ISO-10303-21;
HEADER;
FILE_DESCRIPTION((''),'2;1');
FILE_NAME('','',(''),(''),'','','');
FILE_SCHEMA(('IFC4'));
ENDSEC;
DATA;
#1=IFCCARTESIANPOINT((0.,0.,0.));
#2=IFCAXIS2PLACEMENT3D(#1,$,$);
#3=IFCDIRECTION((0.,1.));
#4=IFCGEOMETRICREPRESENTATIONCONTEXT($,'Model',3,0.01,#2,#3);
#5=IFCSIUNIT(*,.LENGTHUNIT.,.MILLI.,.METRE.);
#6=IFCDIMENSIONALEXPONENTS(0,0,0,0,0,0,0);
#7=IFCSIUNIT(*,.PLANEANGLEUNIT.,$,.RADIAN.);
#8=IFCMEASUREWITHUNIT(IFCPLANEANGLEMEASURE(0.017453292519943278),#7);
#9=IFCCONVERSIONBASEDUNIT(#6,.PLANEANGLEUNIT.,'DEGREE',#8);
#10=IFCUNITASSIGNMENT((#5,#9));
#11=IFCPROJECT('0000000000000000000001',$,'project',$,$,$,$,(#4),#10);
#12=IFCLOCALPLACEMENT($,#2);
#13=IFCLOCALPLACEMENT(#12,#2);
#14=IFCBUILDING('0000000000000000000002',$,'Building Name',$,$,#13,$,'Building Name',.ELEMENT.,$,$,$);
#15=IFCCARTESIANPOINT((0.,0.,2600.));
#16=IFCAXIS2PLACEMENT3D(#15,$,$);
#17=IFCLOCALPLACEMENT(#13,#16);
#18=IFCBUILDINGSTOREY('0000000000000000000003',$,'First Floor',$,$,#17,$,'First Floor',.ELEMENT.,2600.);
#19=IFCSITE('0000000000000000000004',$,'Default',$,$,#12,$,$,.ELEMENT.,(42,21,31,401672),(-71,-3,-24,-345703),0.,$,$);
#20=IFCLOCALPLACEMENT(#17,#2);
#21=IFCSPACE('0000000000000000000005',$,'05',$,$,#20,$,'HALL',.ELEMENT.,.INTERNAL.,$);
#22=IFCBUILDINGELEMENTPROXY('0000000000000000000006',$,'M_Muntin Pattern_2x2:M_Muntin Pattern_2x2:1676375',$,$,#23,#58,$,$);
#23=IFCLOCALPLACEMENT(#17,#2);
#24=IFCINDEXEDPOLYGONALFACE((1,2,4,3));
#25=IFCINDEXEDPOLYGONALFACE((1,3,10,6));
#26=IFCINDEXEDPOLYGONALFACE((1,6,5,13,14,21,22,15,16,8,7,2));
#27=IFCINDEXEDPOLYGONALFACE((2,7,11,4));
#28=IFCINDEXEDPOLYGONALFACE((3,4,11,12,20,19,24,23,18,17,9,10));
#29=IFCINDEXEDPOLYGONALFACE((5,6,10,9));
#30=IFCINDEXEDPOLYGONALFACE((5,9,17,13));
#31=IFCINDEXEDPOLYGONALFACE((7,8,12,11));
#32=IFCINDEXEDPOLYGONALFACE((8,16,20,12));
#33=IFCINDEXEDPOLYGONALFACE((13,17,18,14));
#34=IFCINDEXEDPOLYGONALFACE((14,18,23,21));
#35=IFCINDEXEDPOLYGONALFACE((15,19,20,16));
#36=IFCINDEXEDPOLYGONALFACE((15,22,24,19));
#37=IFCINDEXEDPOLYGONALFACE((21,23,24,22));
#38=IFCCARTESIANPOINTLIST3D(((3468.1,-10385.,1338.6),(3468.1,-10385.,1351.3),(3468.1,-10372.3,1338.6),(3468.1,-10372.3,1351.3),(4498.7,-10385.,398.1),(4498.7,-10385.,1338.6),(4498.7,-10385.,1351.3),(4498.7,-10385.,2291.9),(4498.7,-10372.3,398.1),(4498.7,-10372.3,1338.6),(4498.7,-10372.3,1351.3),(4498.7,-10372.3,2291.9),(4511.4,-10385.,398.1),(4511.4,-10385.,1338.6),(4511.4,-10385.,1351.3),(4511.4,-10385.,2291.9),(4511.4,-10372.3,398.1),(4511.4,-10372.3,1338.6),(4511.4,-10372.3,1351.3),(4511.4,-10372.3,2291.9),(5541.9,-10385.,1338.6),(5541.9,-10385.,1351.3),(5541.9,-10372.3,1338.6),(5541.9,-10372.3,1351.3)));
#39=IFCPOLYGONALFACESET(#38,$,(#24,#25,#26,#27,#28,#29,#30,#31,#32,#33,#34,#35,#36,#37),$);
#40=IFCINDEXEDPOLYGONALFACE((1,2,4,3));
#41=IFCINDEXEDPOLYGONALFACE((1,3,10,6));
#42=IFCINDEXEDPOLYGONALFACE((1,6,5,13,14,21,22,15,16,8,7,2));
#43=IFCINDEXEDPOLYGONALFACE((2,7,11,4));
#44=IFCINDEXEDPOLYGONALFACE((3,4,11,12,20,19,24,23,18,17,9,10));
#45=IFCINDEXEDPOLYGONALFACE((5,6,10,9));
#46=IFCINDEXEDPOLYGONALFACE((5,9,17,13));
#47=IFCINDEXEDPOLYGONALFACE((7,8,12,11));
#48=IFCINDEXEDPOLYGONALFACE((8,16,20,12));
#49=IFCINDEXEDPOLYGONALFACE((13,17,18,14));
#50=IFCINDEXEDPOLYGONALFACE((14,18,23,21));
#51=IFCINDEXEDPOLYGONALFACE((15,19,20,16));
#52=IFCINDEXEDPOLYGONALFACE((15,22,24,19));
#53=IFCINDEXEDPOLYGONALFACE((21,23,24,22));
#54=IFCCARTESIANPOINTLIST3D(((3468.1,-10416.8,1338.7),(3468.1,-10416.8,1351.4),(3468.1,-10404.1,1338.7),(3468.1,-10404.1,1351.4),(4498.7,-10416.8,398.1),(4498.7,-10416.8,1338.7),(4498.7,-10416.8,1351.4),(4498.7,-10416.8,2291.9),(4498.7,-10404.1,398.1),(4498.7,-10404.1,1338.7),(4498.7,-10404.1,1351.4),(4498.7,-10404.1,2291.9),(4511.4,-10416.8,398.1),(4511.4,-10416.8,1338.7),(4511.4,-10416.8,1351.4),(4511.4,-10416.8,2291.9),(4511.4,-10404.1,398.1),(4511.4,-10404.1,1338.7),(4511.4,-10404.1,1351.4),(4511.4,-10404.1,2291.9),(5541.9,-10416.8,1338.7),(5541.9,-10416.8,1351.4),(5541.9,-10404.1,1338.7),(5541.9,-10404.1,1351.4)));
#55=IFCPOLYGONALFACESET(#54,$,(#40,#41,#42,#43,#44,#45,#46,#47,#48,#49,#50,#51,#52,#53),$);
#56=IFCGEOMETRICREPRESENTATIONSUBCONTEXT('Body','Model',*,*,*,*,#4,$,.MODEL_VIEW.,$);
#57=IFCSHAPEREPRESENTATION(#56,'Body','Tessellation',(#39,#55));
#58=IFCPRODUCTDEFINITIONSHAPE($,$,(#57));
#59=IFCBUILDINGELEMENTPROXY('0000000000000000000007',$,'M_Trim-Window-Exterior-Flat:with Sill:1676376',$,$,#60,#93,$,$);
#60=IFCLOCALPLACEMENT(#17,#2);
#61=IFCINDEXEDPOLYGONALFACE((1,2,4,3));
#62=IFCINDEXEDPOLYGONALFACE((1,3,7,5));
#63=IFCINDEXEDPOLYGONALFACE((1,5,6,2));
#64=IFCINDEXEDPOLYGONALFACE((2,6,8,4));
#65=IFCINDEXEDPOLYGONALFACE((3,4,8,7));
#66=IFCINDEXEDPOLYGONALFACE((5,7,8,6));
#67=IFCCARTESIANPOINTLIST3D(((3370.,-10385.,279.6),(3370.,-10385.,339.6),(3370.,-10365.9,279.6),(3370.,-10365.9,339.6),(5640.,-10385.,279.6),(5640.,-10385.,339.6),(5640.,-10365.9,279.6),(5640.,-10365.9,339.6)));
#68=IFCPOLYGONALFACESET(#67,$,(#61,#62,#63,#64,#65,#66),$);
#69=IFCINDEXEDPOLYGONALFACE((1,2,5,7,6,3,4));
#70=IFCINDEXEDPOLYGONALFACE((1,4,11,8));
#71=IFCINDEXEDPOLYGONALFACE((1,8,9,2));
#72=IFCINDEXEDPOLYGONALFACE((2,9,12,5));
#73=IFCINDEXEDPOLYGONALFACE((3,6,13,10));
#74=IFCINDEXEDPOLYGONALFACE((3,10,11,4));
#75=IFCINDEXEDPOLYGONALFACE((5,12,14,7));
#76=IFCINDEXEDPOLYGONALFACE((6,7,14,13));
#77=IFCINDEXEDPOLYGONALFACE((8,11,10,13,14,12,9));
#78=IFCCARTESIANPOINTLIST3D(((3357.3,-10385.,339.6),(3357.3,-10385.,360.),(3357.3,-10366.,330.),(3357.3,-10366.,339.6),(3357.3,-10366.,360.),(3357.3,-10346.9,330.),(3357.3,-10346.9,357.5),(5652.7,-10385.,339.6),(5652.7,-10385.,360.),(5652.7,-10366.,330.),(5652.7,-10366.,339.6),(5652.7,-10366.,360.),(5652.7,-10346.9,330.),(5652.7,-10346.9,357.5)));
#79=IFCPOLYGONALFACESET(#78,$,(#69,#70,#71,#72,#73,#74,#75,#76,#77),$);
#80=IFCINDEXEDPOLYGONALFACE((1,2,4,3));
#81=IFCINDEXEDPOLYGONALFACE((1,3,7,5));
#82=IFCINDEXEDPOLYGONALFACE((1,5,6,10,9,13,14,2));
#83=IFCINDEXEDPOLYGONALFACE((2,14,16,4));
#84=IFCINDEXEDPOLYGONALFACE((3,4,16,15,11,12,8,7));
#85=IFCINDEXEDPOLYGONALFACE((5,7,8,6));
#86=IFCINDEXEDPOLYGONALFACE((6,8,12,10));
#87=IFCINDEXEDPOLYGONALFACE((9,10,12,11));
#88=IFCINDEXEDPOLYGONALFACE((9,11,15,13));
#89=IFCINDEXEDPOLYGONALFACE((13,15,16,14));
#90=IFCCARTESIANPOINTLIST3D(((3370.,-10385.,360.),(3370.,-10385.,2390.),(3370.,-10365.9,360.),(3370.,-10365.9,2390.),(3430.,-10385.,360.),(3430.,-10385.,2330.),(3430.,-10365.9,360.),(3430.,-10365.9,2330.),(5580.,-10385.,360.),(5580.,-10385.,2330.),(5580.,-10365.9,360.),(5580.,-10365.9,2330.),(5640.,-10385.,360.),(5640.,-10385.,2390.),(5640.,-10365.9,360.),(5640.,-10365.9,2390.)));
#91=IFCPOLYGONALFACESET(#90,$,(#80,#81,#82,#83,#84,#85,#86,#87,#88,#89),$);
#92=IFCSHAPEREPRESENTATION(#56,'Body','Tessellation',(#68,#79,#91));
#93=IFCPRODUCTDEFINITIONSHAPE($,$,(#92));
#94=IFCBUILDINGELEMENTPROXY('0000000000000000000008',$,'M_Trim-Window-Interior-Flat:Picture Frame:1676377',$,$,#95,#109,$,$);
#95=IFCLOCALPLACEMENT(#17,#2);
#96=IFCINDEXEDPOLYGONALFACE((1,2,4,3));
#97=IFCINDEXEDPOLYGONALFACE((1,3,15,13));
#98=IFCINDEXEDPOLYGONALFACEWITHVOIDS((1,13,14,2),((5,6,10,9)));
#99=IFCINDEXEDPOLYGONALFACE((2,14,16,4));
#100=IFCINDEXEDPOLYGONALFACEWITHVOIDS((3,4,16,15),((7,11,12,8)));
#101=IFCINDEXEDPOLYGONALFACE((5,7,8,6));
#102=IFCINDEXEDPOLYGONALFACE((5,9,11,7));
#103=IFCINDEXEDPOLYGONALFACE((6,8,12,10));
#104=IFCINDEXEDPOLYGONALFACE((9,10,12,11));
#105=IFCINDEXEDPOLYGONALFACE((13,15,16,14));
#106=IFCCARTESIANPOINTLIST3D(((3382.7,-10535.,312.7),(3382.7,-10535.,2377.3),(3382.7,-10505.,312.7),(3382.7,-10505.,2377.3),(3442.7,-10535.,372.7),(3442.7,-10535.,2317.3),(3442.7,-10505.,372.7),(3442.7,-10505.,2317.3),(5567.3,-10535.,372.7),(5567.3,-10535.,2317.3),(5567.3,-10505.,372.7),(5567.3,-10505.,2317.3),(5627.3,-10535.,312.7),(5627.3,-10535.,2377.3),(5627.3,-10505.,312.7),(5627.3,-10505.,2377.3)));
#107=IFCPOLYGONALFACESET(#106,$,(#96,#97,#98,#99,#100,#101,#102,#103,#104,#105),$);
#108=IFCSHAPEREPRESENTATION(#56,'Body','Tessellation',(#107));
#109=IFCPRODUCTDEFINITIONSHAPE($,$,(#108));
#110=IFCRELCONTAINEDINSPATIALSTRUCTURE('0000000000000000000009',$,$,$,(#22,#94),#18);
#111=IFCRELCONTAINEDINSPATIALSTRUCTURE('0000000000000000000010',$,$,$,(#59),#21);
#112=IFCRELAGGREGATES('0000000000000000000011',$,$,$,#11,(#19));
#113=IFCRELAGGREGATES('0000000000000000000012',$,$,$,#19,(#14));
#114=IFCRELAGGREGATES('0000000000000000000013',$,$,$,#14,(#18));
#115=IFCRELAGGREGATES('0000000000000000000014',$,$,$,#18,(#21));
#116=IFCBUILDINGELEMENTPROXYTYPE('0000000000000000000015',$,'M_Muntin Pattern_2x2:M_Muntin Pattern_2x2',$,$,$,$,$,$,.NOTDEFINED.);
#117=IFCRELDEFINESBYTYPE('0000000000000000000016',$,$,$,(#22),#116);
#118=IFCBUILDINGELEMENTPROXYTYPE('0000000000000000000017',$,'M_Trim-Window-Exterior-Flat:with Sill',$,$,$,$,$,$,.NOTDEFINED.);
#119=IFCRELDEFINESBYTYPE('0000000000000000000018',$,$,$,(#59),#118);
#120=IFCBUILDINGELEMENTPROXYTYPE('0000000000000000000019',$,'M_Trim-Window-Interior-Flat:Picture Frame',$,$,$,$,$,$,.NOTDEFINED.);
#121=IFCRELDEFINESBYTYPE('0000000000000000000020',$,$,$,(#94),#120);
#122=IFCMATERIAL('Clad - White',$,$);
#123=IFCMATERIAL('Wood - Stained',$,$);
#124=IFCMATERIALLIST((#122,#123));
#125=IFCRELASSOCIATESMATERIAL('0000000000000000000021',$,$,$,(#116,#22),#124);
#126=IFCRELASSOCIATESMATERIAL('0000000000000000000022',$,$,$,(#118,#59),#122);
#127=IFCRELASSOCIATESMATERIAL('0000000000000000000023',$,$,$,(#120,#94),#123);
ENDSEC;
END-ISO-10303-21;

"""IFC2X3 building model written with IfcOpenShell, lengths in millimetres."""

from ifc_helpers import new_model, entity, si_unit, converted_unit, direction, frame, frame_2d, origin, place, context, subcontext, project, spatial, polyline, rectangle, outline, extrude, source, transform, mapped, material, material_list, type_object, type_shapes, element, save


model = new_model("IFC2X3")

# Units and contexts
model_context = context("Model", 3, precision=0.01, world=origin(), true_north=direction((0.0, 1.0)))
body_context = subcontext(model_context, "Body", "Model", "MODEL_VIEW")
ifc_project = project(units=[si_unit("LENGTHUNIT", "METRE", prefix="MILLI"), converted_unit("PLANEANGLEUNIT", "DEGREE", entity("IfcPlaneAngleMeasure", 0.017453292519943278), si_unit("PLANEANGLEUNIT", "RADIAN"), dimensions=[0, 0, 0, 0, 0, 0, 0])], contexts=[model_context])

# Site, building, storey
site_placement = place(None, origin())
site = spatial("IfcSite", under=ifc_project, at=site_placement, Name="Default", CompositionType="ELEMENT", RefLatitude=(42, 21, 31, 401672), RefLongitude=(-71, -3, -24, -345703), RefElevation=0.0)
building_placement = place(site_placement, origin())
building = spatial("IfcBuilding", under=site, at=building_placement, Name="Building Name", LongName="Building Name", CompositionType="ELEMENT")
storey_placement = place(building_placement, frame((0.0, 0.0, 2600.0)))
storey = spatial("IfcBuildingStorey", under=building, at=storey_placement, Name="First Floor", LongName="First Floor", CompositionType="ELEMENT", Elevation=2600.0)

# Shared definitions
ifc_material_1 = material(Name="Clad - White")
ifc_material_2 = material(Name="Wood - Stained")
ifc_material_list_1 = material_list([ifc_material_1, ifc_material_2])

# Building element proxy
building_element_proxy_type_1 = type_object("IfcBuildingElementProxyType", Name="M_Muntin Pattern_2x2:M_Muntin Pattern_2x2", PredefinedType="NOTDEFINED", material=ifc_material_list_1)
shared_shape_1 = source(origin(), body_context, "Body", "SweptSolid", [
    extrude(outline(polyline([(6.4, -6.4), (946.9, -6.4), (946.9, 6.3), (6.4, 6.3), (6.4, 1036.9), (-6.3, 1036.9), (-6.3, 6.3), (-946.9, 6.3), (-946.9, -6.4), (-6.3, -6.4), (-6.3, -1036.9), (6.4, -1036.9), (6.4, -6.4)])), frame((0.0, -22.2, 946.9), z_axis=(0.0, 1.0, 0.0), x_axis=(0.0, 0.0, 1.0)), (0.0, 0.0, 1.0), 12.7),
    extrude(outline(polyline([(6.4, -6.4), (946.9, -6.4), (946.9, 6.3), (6.4, 6.3), (6.4, 1036.9), (-6.3, 1036.9), (-6.3, 6.3), (-946.9, 6.3), (-946.9, -6.4), (-6.3, -6.4), (-6.3, -1036.9), (6.4, -1036.9), (6.4, -6.4)])), frame((0.0, 9.5, 946.9), z_axis=(0.0, 1.0, 0.0), x_axis=(0.0, 0.0, 1.0)), (0.0, 0.0, 1.0), 12.7),
])
type_shapes(building_element_proxy_type_1, [shared_shape_1])
proxy_1_placement = place(storey_placement, frame((4505.0, -10394.5, 398.1), z_axis=(0.0, 0.0, 1.0), x_axis=(-1.0, 0.0, 0.0)))
element("IfcBuildingElementProxy", 1, at=proxy_1_placement, inside=storey, type_object=building_element_proxy_type_1, material=ifc_material_list_1, Name="M_Muntin Pattern_2x2:M_Muntin Pattern_2x2:1676375", context=body_context, shape_type="MappedRepresentation", body=[
    mapped(shared_shape_1, transform((0.0, 0.0, 0.0), scale=1.0)),
])

# Shared definitions
space_1_placement = place(storey_placement, origin())
space_1 = spatial("IfcSpace", under=storey, at=space_1_placement, Name="05", LongName="HALL", CompositionType="ELEMENT", InteriorOrExteriorSpace="INTERNAL")

# Building element proxies
building_element_proxy_type_2 = type_object("IfcBuildingElementProxyType", Name="M_Trim-Window-Exterior-Flat:with Sill", PredefinedType="NOTDEFINED", material=ifc_material_1)
shared_shape_2 = source(origin(), body_context, "Body", "SweptSolid", [
    extrude(rectangle(XDim=2270.0, YDim=60.0, at=frame_2d((0.0, 0.0), x_axis=(1.0, 0.0))), frame((0.0, -2020.4, 0.0), z_axis=(0.0, 0.0, 1.0), x_axis=(-1.0, 0.0, 0.0)), (0.0, 0.0, 1.0), 19.0),
    extrude(outline(polyline([(-19.0, -15.2), (0.0, -15.2), (0.0, -5.7), (19.0, -5.7), (19.0, 14.8), (0.0, 14.8), (-19.0, 12.3), (-19.0, -15.2)])), frame((-1147.7, -1984.8, 19.0), z_axis=(1.0, 0.0, 0.0), x_axis=(0.0, 0.0, -1.0)), (0.0, 0.0, 1.0), 2295.4),
    extrude(outline(polyline([(-1030.0, -1135.0), (1000.0, -1135.0), (1000.0, -1075.0), (-970.0, -1075.0), (-970.0, 1075.0), (1000.0, 1075.0), (1000.0, 1135.0), (-1030.0, 1135.0), (-1030.0, -1135.0)])), frame((0.0, -970.0, 0.0), z_axis=(0.0, 0.0, 1.0), x_axis=(0.0, -1.0, 0.0)), (0.0, 0.0, 1.0), 19.0),
])
type_shapes(building_element_proxy_type_2, [shared_shape_2])
proxy_2_placement = place(space_1_placement, frame((4505.0, -10385.0, 2330.0), z_axis=(0.0, 1.0, 0.0), x_axis=(-1.0, 0.0, 0.0)))
element("IfcBuildingElementProxy", 2, at=proxy_2_placement, inside=space_1, type_object=building_element_proxy_type_2, material=ifc_material_1, Name="M_Trim-Window-Exterior-Flat:with Sill:1676376", context=body_context, shape_type="MappedRepresentation", body=[
    mapped(shared_shape_2, transform((0.0, 0.0, 0.0), scale=1.0)),
])
building_element_proxy_type_3 = type_object("IfcBuildingElementProxyType", Name="M_Trim-Window-Interior-Flat:Picture Frame", PredefinedType="NOTDEFINED", material=ifc_material_2)
shared_shape_3 = source(origin(), body_context, "Body", "SweptSolid", [
    extrude(outline(polyline([(-1122.3, -1032.3), (1122.3, -1032.3), (1122.3, 1032.3), (-1122.3, 1032.3), (-1122.3, -1032.3)]), holes=[polyline([(-1062.3, -972.3), (-1062.3, 972.3), (1062.3, 972.3), (1062.3, -972.3), (-1062.3, -972.3)])]), frame((0.0, -985.0, 0.0), z_axis=(0.0, 0.0, 1.0), x_axis=(-1.0, 0.0, 0.0)), (0.0, 0.0, 1.0), 30.0),
])
type_shapes(building_element_proxy_type_3, [shared_shape_3])
proxy_3_placement = place(storey_placement, frame((4505.0, -10505.0, 2330.0), z_axis=(0.0, -1.0, 0.0), x_axis=(1.0, 0.0, 0.0)))
element("IfcBuildingElementProxy", 3, at=proxy_3_placement, inside=storey, type_object=building_element_proxy_type_3, material=ifc_material_2, Name="M_Trim-Window-Interior-Flat:Picture Frame:1676377", context=body_context, shape_type="MappedRepresentation", body=[
    mapped(shared_shape_3, transform((0.0, 0.0, 0.0), scale=1.0)),
])

save(model, "model.ifc")
